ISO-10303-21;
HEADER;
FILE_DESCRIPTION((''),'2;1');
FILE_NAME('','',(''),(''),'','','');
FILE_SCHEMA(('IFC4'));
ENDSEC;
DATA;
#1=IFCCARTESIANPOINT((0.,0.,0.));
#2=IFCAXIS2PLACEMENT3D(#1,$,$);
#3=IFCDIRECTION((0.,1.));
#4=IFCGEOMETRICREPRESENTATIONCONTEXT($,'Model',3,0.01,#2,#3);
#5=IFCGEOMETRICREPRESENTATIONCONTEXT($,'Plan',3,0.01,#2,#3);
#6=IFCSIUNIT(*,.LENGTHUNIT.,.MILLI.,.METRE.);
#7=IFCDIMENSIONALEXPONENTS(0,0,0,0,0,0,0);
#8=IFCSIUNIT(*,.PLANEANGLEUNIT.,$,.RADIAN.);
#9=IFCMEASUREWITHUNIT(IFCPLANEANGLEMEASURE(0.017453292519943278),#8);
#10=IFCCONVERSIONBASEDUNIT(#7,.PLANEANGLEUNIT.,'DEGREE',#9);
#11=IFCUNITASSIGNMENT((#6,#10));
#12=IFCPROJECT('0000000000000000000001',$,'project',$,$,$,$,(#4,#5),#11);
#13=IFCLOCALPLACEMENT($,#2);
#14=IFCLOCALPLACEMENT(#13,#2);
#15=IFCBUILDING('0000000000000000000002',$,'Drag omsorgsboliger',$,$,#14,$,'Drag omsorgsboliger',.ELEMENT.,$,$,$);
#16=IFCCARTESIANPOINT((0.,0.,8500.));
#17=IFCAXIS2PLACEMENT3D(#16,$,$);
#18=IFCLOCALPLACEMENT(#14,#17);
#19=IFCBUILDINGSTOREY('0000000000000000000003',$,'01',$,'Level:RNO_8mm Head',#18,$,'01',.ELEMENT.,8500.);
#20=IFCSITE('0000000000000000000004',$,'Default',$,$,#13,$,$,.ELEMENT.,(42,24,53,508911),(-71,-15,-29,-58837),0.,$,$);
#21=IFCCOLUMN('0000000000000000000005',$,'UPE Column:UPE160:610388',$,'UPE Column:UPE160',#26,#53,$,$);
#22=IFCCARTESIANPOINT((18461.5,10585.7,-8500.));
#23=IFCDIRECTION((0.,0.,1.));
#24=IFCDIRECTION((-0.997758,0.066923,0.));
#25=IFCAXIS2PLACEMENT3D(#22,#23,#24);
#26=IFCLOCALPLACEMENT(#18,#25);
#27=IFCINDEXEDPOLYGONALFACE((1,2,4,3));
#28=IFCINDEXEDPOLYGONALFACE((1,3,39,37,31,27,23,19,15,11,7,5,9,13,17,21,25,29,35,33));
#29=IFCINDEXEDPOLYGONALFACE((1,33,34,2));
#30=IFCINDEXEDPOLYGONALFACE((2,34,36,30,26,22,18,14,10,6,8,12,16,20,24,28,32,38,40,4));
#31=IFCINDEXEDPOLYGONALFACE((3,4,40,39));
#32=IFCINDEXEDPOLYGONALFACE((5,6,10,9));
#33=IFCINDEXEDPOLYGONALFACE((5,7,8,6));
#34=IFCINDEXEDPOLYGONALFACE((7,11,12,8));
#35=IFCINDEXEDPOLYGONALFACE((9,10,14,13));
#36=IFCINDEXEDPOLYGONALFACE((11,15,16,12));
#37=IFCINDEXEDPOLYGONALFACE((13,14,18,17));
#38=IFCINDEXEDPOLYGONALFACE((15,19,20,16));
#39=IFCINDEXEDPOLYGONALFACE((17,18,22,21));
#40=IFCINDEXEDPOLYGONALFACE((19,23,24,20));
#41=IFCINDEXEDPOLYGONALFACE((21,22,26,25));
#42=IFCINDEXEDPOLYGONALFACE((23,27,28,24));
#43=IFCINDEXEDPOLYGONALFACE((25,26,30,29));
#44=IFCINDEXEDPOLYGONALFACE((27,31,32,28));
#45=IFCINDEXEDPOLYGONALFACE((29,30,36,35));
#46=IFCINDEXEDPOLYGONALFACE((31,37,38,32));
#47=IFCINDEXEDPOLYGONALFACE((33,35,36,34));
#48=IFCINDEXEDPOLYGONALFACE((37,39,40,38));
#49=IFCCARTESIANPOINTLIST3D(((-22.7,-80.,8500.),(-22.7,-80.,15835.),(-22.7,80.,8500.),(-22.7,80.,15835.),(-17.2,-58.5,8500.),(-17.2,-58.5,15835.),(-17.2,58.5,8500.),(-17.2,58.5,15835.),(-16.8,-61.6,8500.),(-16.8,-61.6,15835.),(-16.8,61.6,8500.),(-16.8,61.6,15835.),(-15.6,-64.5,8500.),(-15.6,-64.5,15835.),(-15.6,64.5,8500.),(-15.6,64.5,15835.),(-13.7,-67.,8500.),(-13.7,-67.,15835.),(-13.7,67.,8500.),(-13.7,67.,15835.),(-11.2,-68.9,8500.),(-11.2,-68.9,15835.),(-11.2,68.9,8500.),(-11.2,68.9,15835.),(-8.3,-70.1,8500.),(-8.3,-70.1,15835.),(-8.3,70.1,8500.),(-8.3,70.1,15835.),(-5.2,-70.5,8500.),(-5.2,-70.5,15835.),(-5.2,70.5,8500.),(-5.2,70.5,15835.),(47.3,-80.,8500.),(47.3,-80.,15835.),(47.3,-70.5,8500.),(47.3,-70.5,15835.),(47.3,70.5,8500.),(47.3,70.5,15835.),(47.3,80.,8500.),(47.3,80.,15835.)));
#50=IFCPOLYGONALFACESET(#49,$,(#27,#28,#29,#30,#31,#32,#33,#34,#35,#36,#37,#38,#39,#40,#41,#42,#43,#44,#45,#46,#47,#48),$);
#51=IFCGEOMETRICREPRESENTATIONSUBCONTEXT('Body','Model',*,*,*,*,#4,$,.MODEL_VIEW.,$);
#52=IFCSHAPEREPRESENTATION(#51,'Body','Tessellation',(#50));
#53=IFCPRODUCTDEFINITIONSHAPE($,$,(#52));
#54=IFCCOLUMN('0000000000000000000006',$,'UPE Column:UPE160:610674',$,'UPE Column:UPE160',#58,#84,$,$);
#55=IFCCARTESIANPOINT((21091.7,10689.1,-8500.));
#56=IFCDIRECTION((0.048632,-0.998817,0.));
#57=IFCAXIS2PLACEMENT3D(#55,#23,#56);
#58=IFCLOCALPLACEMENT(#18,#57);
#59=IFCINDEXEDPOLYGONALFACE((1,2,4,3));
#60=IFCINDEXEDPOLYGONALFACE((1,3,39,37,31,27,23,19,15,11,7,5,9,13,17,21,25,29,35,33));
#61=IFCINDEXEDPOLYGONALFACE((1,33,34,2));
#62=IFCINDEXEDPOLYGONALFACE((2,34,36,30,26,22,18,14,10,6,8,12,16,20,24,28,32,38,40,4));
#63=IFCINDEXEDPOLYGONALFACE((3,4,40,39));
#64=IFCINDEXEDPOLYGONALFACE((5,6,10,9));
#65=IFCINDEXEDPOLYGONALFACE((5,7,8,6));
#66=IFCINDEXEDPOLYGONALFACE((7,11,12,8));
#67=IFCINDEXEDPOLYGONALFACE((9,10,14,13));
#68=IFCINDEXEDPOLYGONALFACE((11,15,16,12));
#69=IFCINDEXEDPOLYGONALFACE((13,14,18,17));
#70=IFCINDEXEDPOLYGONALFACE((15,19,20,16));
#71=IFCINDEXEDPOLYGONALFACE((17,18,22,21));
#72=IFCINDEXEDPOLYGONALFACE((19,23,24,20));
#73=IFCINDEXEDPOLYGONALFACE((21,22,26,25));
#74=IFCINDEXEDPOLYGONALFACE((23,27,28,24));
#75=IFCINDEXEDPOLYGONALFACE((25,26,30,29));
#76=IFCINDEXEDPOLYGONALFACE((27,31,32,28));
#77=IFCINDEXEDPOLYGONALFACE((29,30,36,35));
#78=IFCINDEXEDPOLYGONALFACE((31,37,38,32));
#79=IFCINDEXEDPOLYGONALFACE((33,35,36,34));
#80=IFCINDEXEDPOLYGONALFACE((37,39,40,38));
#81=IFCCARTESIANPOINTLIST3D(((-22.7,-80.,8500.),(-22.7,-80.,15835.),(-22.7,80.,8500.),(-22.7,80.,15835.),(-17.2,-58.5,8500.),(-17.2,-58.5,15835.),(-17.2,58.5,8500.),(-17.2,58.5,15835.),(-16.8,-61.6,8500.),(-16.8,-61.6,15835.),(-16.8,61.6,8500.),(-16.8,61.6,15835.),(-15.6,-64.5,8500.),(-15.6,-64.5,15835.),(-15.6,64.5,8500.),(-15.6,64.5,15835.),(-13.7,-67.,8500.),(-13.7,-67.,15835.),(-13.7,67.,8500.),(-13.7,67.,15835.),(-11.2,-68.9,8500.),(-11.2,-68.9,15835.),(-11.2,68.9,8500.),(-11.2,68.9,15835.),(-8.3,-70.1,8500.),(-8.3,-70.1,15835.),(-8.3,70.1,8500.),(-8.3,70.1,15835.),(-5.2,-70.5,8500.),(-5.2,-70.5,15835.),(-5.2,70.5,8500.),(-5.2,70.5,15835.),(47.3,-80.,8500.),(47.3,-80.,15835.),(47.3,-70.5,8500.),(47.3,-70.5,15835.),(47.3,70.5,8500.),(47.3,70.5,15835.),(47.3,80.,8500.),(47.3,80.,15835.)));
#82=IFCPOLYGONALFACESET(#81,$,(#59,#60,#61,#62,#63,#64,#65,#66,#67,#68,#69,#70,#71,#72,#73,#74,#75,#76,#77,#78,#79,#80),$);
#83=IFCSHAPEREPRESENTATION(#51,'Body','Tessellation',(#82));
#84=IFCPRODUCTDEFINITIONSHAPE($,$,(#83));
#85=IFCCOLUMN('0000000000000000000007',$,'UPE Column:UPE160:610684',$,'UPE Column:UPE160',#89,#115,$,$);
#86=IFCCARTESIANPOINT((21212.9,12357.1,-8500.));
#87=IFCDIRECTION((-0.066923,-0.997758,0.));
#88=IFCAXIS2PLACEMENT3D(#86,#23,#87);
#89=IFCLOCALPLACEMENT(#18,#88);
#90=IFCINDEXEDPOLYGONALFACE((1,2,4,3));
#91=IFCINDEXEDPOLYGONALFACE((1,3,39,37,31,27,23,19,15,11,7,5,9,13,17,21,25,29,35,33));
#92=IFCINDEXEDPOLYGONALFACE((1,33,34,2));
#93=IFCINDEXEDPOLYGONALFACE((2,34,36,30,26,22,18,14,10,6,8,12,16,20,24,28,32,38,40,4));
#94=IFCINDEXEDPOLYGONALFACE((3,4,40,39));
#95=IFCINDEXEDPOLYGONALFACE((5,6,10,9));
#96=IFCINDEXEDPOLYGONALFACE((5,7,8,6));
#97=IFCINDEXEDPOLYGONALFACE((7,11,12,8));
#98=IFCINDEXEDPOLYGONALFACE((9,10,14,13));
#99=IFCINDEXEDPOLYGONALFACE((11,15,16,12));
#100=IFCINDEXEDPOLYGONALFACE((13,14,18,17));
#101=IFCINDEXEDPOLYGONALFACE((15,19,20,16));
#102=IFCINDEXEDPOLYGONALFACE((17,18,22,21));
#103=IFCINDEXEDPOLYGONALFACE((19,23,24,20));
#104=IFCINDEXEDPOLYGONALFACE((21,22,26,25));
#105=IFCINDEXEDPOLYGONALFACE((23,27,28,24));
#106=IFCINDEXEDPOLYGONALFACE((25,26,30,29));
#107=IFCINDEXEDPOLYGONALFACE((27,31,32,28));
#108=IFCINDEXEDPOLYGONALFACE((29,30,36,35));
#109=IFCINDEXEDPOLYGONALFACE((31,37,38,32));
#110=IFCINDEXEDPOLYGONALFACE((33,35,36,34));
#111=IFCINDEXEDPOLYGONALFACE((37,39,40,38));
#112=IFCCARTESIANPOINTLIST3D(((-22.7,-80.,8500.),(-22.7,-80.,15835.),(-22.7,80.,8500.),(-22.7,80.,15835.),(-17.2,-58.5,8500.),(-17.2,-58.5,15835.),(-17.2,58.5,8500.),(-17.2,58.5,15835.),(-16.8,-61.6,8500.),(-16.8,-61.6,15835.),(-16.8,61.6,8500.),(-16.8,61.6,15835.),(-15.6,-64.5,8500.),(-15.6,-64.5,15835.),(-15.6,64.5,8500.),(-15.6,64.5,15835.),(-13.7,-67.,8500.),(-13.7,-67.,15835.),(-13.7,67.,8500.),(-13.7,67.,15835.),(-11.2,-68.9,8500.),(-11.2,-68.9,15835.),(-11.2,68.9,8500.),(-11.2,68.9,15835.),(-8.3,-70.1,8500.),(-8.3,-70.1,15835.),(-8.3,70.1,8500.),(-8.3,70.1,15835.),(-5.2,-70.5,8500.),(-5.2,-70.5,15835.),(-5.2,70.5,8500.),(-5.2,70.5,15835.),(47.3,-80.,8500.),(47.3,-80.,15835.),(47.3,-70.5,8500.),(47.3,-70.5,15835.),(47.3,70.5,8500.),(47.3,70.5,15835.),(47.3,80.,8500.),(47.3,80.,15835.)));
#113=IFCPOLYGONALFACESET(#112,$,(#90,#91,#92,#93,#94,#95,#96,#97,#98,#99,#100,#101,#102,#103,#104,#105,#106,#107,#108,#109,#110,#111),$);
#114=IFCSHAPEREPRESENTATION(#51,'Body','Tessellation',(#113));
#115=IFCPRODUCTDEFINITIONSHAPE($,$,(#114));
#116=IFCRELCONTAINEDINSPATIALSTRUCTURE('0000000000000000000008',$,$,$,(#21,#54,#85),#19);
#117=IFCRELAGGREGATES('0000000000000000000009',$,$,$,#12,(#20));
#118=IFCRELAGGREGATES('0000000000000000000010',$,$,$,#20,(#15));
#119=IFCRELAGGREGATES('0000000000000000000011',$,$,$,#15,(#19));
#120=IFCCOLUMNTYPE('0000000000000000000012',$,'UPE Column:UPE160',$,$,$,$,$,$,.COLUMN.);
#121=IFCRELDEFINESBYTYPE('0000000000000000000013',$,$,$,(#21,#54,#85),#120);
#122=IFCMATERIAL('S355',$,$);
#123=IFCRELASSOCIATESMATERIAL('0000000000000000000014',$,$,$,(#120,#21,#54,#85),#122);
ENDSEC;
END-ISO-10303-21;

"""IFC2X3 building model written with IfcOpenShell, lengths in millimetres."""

from ifc_helpers import new_model, entity, si_unit, converted_unit, direction, frame, frame_2d, origin, place, context, subcontext, project, spatial, polyline, circle_curve, parameter, trimmed, segment, composite_curve, outline, extrude, source, transform, mapped, material, type_object, type_shapes, element, save


model = new_model("IFC2X3")

# Units and contexts
model_context = context("Model", 3, precision=0.01, world=origin(), true_north=direction((0.0, 1.0)))
plan_context = context("Plan", 3, precision=0.01, world=origin(), true_north=direction((0.0, 1.0)))
body_context = subcontext(model_context, "Body", "Model", "MODEL_VIEW")
ifc_project = project(units=[si_unit("LENGTHUNIT", "METRE", prefix="MILLI"), converted_unit("PLANEANGLEUNIT", "DEGREE", entity("IfcPlaneAngleMeasure", 0.017453292519943278), si_unit("PLANEANGLEUNIT", "RADIAN"), dimensions=[0, 0, 0, 0, 0, 0, 0])], contexts=[model_context, plan_context])

# Site, building, storey
site_placement = place(None, origin())
site = spatial("IfcSite", under=ifc_project, at=site_placement, Name="Default", CompositionType="ELEMENT", RefLatitude=(42, 24, 53, 508911), RefLongitude=(-71, -15, -29, -58837), RefElevation=0.0)
building_placement = place(site_placement, origin())
building = spatial("IfcBuilding", under=site, at=building_placement, Name="Drag omsorgsboliger", LongName="Drag omsorgsboliger", CompositionType="ELEMENT")
storey_placement = place(building_placement, frame((0.0, 0.0, 8500.0)))
storey = spatial("IfcBuildingStorey", under=building, at=storey_placement, Name="01", ObjectType="Level:RNO_8mm Head", LongName="01", CompositionType="ELEMENT", Elevation=8500.0)

# Columns
ifc_material_1 = material(Name="S355")
column_type_1 = type_object("IfcColumnType", Name="UPE Column:UPE160", PredefinedType="COLUMN", material=ifc_material_1)
shared_shape_1 = source(origin(), body_context, "Body", "SweptSolid", [
    extrude(outline(composite_curve([segment(polyline([(-80.0, -37.4), (-70.5, -37.4)]), True, "CONTINUOUS"), segment(polyline([(-70.5, -37.4), (-70.5, 15.1)]), True, "CONTINUOUS"), segment(trimmed(circle_curve(frame_2d((-58.5, 15.1), x_axis=(0.0, -1.0)), 12.0), [parameter(180.0)], [parameter(270.0)], True, "PARAMETER"), False, "CONTINUOUS"), segment(polyline([(-58.5, 27.1), (58.5, 27.1)]), True, "CONTINUOUS"), segment(trimmed(circle_curve(frame_2d((58.5, 15.1), x_axis=(0.0, -1.0)), 12.0), [parameter(90.0)], [parameter(180.0)], True, "PARAMETER"), False, "CONTINUOUS"), segment(polyline([(70.5, 15.1), (70.5, -37.4)]), True, "CONTINUOUS"), segment(polyline([(70.5, -37.4), (80.0, -37.4)]), True, "CONTINUOUS"), segment(polyline([(80.0, -37.4), (80.0, 32.6)]), True, "CONTINUOUS"), segment(polyline([(80.0, 32.6), (-80.0, 32.6)]), True, "CONTINUOUS"), segment(polyline([(-80.0, 32.6), (-80.0, -37.4)]), True, "CONTINUOUS")], self_intersect=False)), frame((9.9, 0.0, 8500.0), z_axis=(0.0, 0.0, 1.0), x_axis=(0.0, 1.0, 0.0)), (0.0, 0.0, 1.0), 7335.0),
])
type_shapes(column_type_1, [shared_shape_1])
for number, where, z_axis, x_axis, name in (
    (1, (18461.5, 10585.7, -8500.0), (0.0, 0.0, 1.0), (-0.997758, 0.066923, 0.0), "UPE Column:UPE160:610388"),
    (2, (21091.7, 10689.1, -8500.0), (0.0, 0.0, 1.0), (0.048632, -0.998817, 0.0), "UPE Column:UPE160:610674"),
    (3, (21212.9, 12357.1, -8500.0), (0.0, 0.0, 1.0), (-0.066923, -0.997758, 0.0), "UPE Column:UPE160:610684"),
):
    element("IfcColumn", number, at=place(storey_placement, frame(where, z_axis=z_axis, x_axis=x_axis)), inside=storey, type_object=column_type_1, material=ifc_material_1, Name=name, ObjectType="UPE Column:UPE160", context=body_context, shape_type="MappedRepresentation", body=[
        mapped(shared_shape_1, transform((0.0, 0.0, 0.0), scale=1.0)),
    ])

save(model, "model.ifc")
